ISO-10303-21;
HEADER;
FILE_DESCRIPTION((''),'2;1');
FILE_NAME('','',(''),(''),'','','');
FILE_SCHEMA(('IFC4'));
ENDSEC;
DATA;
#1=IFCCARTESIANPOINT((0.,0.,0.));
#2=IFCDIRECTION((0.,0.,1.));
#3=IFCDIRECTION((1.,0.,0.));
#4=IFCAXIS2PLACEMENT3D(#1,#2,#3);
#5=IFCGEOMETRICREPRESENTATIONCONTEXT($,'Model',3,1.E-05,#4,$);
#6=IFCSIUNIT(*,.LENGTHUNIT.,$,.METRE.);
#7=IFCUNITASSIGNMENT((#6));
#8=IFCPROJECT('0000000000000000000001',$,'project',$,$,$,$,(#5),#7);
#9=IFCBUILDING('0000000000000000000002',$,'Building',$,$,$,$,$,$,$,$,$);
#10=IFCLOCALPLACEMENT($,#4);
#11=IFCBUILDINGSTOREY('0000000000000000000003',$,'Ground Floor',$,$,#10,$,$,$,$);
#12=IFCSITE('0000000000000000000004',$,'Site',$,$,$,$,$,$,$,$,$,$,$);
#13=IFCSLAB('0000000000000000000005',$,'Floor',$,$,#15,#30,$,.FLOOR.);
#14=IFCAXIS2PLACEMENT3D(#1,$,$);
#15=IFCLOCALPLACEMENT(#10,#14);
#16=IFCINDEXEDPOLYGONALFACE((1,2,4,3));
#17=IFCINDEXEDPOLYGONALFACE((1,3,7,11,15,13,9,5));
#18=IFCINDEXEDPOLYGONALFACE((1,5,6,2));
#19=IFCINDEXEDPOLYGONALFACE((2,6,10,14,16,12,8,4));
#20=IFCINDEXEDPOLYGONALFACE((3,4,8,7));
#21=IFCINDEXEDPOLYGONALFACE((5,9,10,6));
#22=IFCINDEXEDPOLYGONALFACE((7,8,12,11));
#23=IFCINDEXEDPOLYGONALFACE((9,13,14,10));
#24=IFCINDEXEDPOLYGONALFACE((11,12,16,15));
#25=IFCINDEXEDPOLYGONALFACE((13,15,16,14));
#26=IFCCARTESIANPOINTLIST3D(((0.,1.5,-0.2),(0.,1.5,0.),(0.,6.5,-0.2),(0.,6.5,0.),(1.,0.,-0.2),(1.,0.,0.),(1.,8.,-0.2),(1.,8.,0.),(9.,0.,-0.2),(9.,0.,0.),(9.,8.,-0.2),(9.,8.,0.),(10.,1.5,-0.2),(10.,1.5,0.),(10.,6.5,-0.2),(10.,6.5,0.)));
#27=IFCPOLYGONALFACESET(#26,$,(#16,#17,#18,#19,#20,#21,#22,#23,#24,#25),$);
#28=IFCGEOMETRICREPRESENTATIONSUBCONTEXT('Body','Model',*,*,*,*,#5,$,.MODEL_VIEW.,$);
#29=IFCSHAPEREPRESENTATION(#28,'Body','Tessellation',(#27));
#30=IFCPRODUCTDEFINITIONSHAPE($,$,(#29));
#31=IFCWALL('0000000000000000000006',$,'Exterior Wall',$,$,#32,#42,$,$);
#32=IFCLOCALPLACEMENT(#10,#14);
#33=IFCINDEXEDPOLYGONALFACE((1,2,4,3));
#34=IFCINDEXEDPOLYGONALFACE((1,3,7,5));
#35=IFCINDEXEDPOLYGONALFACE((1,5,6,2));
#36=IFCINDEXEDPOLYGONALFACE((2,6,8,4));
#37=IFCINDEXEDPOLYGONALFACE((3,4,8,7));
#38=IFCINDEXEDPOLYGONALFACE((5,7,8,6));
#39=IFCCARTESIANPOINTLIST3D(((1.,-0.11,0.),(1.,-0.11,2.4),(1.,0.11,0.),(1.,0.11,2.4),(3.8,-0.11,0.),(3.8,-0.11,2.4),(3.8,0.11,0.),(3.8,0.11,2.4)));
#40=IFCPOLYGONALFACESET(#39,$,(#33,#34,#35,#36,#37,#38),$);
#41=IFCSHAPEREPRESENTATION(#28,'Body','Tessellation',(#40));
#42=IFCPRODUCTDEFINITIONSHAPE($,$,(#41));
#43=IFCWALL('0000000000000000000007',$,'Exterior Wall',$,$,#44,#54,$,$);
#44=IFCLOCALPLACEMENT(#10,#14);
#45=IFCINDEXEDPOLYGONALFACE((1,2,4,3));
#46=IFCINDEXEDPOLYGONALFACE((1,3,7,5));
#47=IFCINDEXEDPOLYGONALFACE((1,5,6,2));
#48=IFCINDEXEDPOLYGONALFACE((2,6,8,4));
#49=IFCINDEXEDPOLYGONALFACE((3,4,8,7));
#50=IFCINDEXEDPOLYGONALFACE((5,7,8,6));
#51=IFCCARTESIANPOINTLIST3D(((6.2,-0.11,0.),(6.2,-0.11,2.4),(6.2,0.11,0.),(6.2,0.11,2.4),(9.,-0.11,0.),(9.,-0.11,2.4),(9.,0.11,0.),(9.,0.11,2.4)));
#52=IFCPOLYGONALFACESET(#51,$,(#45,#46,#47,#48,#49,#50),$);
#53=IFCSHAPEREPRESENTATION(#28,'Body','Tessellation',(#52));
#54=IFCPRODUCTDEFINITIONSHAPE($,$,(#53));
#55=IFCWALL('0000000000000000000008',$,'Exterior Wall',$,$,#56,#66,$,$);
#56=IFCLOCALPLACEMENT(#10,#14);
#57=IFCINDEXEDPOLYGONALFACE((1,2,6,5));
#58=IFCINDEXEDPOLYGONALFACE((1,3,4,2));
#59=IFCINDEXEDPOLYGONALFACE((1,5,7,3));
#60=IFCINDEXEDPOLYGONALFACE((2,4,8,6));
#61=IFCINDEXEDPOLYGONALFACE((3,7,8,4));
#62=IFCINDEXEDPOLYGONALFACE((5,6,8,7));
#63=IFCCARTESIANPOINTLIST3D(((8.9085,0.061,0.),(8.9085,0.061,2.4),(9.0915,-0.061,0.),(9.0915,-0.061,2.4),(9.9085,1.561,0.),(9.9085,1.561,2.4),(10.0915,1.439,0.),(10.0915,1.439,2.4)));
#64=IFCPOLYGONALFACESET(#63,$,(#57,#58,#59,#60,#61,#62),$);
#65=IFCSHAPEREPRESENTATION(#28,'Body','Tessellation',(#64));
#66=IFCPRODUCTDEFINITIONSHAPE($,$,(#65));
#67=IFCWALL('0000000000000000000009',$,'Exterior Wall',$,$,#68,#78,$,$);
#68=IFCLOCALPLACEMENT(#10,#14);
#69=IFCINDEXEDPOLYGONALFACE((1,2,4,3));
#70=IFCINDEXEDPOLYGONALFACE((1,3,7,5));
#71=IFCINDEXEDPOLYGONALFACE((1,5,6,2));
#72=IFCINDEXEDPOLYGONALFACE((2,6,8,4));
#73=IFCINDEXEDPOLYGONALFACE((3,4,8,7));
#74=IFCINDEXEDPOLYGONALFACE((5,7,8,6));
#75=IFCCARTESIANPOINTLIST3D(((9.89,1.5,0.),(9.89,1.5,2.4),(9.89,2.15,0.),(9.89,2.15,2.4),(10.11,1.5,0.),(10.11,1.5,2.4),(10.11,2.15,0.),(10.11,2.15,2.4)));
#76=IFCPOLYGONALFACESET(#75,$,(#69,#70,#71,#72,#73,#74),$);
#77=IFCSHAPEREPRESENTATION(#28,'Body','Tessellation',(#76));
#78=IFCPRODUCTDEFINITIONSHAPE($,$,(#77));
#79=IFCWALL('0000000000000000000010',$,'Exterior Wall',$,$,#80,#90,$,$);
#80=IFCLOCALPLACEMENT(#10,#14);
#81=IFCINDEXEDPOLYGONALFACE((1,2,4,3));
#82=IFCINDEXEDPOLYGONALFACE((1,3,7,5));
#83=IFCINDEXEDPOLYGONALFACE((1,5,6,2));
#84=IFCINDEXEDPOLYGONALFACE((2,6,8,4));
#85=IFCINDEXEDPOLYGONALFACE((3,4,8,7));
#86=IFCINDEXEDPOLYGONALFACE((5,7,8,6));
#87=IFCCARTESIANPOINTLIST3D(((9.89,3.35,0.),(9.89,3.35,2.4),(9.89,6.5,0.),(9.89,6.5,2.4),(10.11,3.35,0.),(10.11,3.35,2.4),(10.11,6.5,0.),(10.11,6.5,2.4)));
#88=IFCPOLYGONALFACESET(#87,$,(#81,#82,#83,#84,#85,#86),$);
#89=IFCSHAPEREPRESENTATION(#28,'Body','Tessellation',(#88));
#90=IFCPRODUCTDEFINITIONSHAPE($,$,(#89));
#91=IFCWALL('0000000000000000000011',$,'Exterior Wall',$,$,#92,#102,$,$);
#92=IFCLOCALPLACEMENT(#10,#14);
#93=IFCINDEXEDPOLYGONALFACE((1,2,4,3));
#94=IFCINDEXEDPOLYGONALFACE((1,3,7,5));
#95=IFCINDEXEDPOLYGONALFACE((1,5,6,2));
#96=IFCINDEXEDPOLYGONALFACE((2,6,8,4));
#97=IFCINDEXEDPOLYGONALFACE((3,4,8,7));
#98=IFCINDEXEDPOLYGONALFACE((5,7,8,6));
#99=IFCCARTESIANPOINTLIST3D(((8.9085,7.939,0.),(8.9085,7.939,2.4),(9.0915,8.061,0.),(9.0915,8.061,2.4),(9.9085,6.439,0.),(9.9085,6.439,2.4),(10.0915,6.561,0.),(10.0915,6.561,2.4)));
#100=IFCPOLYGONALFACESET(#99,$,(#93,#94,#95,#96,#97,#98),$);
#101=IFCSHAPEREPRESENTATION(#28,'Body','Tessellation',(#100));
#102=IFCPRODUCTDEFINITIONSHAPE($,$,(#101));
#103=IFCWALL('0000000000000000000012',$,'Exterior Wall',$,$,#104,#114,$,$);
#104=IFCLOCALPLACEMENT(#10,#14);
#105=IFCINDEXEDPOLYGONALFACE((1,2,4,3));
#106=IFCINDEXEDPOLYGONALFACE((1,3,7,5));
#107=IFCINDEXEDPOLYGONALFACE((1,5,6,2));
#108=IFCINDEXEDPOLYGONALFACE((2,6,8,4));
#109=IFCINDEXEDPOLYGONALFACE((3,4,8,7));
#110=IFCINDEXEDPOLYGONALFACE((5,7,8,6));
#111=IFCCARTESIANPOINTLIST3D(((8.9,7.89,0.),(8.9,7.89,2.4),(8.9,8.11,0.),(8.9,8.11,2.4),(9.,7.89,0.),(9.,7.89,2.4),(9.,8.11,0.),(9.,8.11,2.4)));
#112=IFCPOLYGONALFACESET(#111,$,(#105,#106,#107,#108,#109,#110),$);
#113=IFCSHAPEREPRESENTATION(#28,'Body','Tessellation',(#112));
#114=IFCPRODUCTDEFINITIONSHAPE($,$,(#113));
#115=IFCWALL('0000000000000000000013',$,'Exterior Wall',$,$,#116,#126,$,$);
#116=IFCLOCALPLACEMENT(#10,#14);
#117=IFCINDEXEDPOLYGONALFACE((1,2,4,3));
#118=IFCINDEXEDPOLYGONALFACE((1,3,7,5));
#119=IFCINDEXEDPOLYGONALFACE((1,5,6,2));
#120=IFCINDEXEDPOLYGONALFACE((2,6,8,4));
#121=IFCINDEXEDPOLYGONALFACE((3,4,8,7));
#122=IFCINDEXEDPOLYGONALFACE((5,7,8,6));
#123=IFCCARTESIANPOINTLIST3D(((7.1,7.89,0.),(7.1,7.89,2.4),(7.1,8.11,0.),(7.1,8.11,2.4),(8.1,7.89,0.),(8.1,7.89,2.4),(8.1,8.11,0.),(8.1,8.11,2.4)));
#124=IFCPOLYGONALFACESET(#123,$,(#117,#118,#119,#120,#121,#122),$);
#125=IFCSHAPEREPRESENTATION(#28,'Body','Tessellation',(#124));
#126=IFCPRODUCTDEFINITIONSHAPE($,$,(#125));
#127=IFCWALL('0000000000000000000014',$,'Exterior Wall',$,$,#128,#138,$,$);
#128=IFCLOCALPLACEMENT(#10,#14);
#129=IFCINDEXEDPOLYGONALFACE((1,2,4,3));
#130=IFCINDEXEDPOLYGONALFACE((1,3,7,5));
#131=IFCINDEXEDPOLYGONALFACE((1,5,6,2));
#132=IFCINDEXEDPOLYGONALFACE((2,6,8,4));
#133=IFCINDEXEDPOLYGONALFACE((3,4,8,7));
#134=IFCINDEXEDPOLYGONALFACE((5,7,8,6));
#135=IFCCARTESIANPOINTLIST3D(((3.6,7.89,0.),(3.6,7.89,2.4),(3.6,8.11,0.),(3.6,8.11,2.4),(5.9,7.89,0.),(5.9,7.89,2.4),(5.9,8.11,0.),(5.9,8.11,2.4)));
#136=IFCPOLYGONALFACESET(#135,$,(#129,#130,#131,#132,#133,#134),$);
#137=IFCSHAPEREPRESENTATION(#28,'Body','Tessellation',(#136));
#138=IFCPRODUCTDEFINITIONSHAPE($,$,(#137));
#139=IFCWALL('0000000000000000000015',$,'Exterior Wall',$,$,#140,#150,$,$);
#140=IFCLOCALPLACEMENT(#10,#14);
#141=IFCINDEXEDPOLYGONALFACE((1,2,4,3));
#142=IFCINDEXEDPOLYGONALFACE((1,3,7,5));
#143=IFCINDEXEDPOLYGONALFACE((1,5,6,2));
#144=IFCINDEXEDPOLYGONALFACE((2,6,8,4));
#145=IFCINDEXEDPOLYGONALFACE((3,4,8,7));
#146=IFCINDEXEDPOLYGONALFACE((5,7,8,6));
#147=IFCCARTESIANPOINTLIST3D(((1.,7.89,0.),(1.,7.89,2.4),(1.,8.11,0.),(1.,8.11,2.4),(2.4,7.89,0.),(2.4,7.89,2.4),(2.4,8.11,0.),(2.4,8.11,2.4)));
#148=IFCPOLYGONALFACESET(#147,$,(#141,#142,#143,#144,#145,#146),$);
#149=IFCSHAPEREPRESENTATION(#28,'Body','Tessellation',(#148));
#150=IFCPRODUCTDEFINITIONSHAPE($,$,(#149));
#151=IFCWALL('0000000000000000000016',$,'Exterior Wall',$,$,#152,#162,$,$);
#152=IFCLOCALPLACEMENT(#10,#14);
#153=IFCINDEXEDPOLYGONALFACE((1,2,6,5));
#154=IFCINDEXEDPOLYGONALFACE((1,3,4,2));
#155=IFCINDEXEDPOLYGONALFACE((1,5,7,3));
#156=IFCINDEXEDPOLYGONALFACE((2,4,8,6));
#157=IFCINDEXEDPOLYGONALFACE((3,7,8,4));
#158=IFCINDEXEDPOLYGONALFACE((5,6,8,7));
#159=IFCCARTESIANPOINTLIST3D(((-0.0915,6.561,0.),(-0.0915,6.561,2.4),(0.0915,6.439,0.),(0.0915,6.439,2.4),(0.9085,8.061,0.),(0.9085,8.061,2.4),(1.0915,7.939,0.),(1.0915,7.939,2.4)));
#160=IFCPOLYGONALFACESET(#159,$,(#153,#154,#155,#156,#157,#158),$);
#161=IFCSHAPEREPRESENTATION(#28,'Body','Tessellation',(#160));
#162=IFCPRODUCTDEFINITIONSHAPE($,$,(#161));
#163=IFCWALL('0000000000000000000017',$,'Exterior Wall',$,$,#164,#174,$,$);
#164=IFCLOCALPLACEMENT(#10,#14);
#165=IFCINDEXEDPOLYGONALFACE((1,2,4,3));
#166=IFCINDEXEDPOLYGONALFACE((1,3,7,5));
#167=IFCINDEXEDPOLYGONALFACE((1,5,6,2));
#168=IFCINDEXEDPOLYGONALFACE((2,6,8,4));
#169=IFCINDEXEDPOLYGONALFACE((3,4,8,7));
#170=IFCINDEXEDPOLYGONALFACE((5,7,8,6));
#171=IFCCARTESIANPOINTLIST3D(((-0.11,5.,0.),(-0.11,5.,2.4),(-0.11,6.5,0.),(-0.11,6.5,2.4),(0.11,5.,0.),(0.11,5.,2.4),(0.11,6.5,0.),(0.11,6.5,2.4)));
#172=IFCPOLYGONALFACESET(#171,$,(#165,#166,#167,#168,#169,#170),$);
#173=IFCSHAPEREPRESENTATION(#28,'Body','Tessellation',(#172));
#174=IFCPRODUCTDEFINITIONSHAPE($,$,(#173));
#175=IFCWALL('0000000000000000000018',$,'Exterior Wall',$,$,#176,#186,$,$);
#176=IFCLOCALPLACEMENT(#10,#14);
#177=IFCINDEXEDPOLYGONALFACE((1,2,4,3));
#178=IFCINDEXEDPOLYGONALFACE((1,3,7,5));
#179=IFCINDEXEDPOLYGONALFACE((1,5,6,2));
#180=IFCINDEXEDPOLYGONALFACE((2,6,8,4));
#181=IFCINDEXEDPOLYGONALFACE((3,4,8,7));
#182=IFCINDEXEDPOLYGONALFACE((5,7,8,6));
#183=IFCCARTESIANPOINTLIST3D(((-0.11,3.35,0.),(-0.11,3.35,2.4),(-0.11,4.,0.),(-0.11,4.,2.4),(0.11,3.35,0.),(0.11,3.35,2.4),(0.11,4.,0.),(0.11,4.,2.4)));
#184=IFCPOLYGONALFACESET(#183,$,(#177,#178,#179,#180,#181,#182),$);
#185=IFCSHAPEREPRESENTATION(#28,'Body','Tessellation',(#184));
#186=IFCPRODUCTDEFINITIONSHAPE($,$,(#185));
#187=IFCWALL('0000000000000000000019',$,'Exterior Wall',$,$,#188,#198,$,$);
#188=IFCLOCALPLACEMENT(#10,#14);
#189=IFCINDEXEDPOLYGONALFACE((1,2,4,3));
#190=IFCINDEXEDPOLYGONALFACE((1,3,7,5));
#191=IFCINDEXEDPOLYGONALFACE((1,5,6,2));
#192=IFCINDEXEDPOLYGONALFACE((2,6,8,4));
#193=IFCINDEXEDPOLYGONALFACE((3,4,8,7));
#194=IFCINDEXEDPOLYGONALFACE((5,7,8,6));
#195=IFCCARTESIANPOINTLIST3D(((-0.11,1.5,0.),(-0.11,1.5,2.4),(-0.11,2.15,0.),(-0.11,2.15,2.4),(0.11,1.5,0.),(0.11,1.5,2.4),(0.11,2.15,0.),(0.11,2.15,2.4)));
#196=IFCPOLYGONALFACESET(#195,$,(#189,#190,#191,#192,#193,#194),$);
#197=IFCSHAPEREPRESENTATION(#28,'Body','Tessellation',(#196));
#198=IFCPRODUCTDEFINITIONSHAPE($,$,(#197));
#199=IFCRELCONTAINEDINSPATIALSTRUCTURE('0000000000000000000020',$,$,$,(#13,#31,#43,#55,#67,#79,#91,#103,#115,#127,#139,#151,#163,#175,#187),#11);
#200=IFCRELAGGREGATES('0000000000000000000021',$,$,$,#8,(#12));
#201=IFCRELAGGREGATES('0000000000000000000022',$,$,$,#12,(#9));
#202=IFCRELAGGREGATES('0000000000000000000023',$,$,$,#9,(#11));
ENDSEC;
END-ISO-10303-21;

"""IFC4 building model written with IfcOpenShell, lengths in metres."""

from ifc_helpers import new_model, si_unit, frame, origin_with_axes, place, context, subcontext, project, spatial, indexed_curve, outline, extrude, element, save


model = new_model("IFC4")

# Units and contexts
model_context = context("Model", 3, precision=1e-05, world=origin_with_axes())
body_context = subcontext(model_context, "Body", "Model", "MODEL_VIEW")
ifc_project = project(units=[si_unit("LENGTHUNIT", "METRE")], contexts=[model_context])

# Site, building, storey
site = spatial("IfcSite", under=ifc_project, Name="Site")
building = spatial("IfcBuilding", under=site, Name="Building")
storey_placement = place(None, origin_with_axes())
storey = spatial("IfcBuildingStorey", under=building, at=storey_placement, Name="Ground Floor")

# Slab
slab_placement = place(storey_placement, frame((0.0, 0.0, -0.2), z_axis=(0.0, 0.0, 1.0), x_axis=(1.0, 0.0, 0.0)))
element("IfcSlab", 1, at=slab_placement, inside=storey, Name="Floor", PredefinedType="FLOOR", context=body_context, shape_type="SweptSolid", body=[
    extrude(outline(indexed_curve([(1.0, 0.0), (9.0, 0.0), (10.0, 1.5), (10.0, 6.5), (9.0, 8.0), (1.0, 8.0), (0.0, 6.5), (0.0, 1.5)])), None, (0.0, 0.0, 1.0), 0.2),
])

# Walls
for number, where, z_axis, x_axis, name in (
    (2, (1.0, 0.0, 0.0), (0.0, 0.0, 1.0), (1.0, 0.0, 0.0), "Exterior Wall"),
    (3, (6.2, 0.0, 0.0), (0.0, 0.0, 1.0), (1.0, 0.0, 0.0), "Exterior Wall"),
):
    element("IfcWall", number, at=place(storey_placement, frame(where, z_axis=z_axis, x_axis=x_axis)), inside=storey, Name=name, context=body_context, shape_type="SweptSolid", body=[
        extrude(outline(indexed_curve([(0.0, 0.0), (0.0, 0.22), (2.8, 0.22), (2.8, 0.0), (0.0, 0.0)], self_intersect=False)), frame((0.0, -0.11, 0.0), z_axis=(0.0, 0.0, 1.0), x_axis=(1.0, 0.0, 0.0)), (0.0, 0.0, 1.0), 2.4),
    ])
wall_1_placement = place(storey_placement, frame((9.0, 0.0, 0.0), z_axis=(0.0, 0.0, 1.0), x_axis=(0.5547, 0.83205, 0.0)))
element("IfcWall", 4, at=wall_1_placement, inside=storey, Name="Exterior Wall", context=body_context, shape_type="SweptSolid", body=[
    extrude(outline(indexed_curve([(0.0, 0.0), (0.0, 0.22), (1.8028, 0.22), (1.8028, 0.0), (0.0, 0.0)], self_intersect=False)), frame((0.0, -0.11, 0.0), z_axis=(0.0, 0.0, 1.0), x_axis=(1.0, 0.0, 0.0)), (0.0, 0.0, 1.0), 2.4),
])
wall_2_placement = place(storey_placement, frame((10.0, 1.5, 0.0), z_axis=(0.0, 0.0, 1.0), x_axis=(0.0, 1.0, 0.0)))
element("IfcWall", 5, at=wall_2_placement, inside=storey, Name="Exterior Wall", context=body_context, shape_type="SweptSolid", body=[
    extrude(outline(indexed_curve([(0.0, 0.0), (0.0, 0.22), (0.65, 0.22), (0.65, 0.0), (0.0, 0.0)], self_intersect=False)), frame((0.0, -0.11, 0.0), z_axis=(0.0, 0.0, 1.0), x_axis=(1.0, 0.0, 0.0)), (0.0, 0.0, 1.0), 2.4),
])
wall_3_placement = place(storey_placement, frame((10.0, 3.35, 0.0), z_axis=(0.0, 0.0, 1.0), x_axis=(0.0, 1.0, 0.0)))
element("IfcWall", 6, at=wall_3_placement, inside=storey, Name="Exterior Wall", context=body_context, shape_type="SweptSolid", body=[
    extrude(outline(indexed_curve([(0.0, 0.0), (0.0, 0.22), (3.15, 0.22), (3.15, 0.0), (0.0, 0.0)], self_intersect=False)), frame((0.0, -0.11, 0.0), z_axis=(0.0, 0.0, 1.0), x_axis=(1.0, 0.0, 0.0)), (0.0, 0.0, 1.0), 2.4),
])
wall_4_placement = place(storey_placement, frame((10.0, 6.5, 0.0), z_axis=(0.0, 0.0, 1.0), x_axis=(-0.5547, 0.83205, 0.0)))
element("IfcWall", 7, at=wall_4_placement, inside=storey, Name="Exterior Wall", context=body_context, shape_type="SweptSolid", body=[
    extrude(outline(indexed_curve([(0.0, 0.0), (0.0, 0.22), (1.8028, 0.22), (1.8028, 0.0), (0.0, 0.0)], self_intersect=False)), frame((0.0, -0.11, 0.0), z_axis=(0.0, 0.0, 1.0), x_axis=(1.0, 0.0, 0.0)), (0.0, 0.0, 1.0), 2.4),
])
wall_5_placement = place(storey_placement, frame((9.0, 8.0, 0.0), z_axis=(0.0, 0.0, 1.0), x_axis=(-1.0, 0.0, 0.0)))
element("IfcWall", 8, at=wall_5_placement, inside=storey, Name="Exterior Wall", context=body_context, shape_type="SweptSolid", body=[
    extrude(outline(indexed_curve([(0.0, 0.0), (0.0, 0.22), (0.1, 0.22), (0.1, 0.0), (0.0, 0.0)], self_intersect=False)), frame((0.0, -0.11, 0.0), z_axis=(0.0, 0.0, 1.0), x_axis=(1.0, 0.0, 0.0)), (0.0, 0.0, 1.0), 2.4),
])
wall_6_placement = place(storey_placement, frame((8.1, 8.0, 0.0), z_axis=(0.0, 0.0, 1.0), x_axis=(-1.0, 0.0, 0.0)))
element("IfcWall", 9, at=wall_6_placement, inside=storey, Name="Exterior Wall", context=body_context, shape_type="SweptSolid", body=[
    extrude(outline(indexed_curve([(0.0, 0.0), (0.0, 0.22), (1.0, 0.22), (1.0, 0.0), (0.0, 0.0)], self_intersect=False)), frame((0.0, -0.11, 0.0), z_axis=(0.0, 0.0, 1.0), x_axis=(1.0, 0.0, 0.0)), (0.0, 0.0, 1.0), 2.4),
])
wall_7_placement = place(storey_placement, frame((5.9, 8.0, 0.0), z_axis=(0.0, 0.0, 1.0), x_axis=(-1.0, 0.0, 0.0)))
element("IfcWall", 10, at=wall_7_placement, inside=storey, Name="Exterior Wall", context=body_context, shape_type="SweptSolid", body=[
    extrude(outline(indexed_curve([(0.0, 0.0), (0.0, 0.22), (2.3, 0.22), (2.3, 0.0), (0.0, 0.0)], self_intersect=False)), frame((0.0, -0.11, 0.0), z_axis=(0.0, 0.0, 1.0), x_axis=(1.0, 0.0, 0.0)), (0.0, 0.0, 1.0), 2.4),
])
wall_8_placement = place(storey_placement, frame((2.4, 8.0, 0.0), z_axis=(0.0, 0.0, 1.0), x_axis=(-1.0, 0.0, 0.0)))
element("IfcWall", 11, at=wall_8_placement, inside=storey, Name="Exterior Wall", context=body_context, shape_type="SweptSolid", body=[
    extrude(outline(indexed_curve([(0.0, 0.0), (0.0, 0.22), (1.4, 0.22), (1.4, 0.0), (0.0, 0.0)], self_intersect=False)), frame((0.0, -0.11, 0.0), z_axis=(0.0, 0.0, 1.0), x_axis=(1.0, 0.0, 0.0)), (0.0, 0.0, 1.0), 2.4),
])
wall_9_placement = place(storey_placement, frame((1.0, 8.0, 0.0), z_axis=(0.0, 0.0, 1.0), x_axis=(-0.5547, -0.83205, 0.0)))
element("IfcWall", 12, at=wall_9_placement, inside=storey, Name="Exterior Wall", context=body_context, shape_type="SweptSolid", body=[
    extrude(outline(indexed_curve([(0.0, 0.0), (0.0, 0.22), (1.8028, 0.22), (1.8028, 0.0), (0.0, 0.0)], self_intersect=False)), frame((0.0, -0.11, 0.0), z_axis=(0.0, 0.0, 1.0), x_axis=(1.0, 0.0, 0.0)), (0.0, 0.0, 1.0), 2.4),
])
wall_10_placement = place(storey_placement, frame((0.0, 6.5, 0.0), z_axis=(0.0, 0.0, 1.0), x_axis=(0.0, -1.0, 0.0)))
element("IfcWall", 13, at=wall_10_placement, inside=storey, Name="Exterior Wall", context=body_context, shape_type="SweptSolid", body=[
    extrude(outline(indexed_curve([(0.0, 0.0), (0.0, 0.22), (1.5, 0.22), (1.5, 0.0), (0.0, 0.0)], self_intersect=False)), frame((0.0, -0.11, 0.0), z_axis=(0.0, 0.0, 1.0), x_axis=(1.0, 0.0, 0.0)), (0.0, 0.0, 1.0), 2.4),
])
wall_11_placement = place(storey_placement, frame((0.0, 4.0, 0.0), z_axis=(0.0, 0.0, 1.0), x_axis=(0.0, -1.0, 0.0)))
element("IfcWall", 14, at=wall_11_placement, inside=storey, Name="Exterior Wall", context=body_context, shape_type="SweptSolid", body=[
    extrude(outline(indexed_curve([(0.0, 0.0), (0.0, 0.22), (0.65, 0.22), (0.65, 0.0), (0.0, 0.0)], self_intersect=False)), frame((0.0, -0.11, 0.0), z_axis=(0.0, 0.0, 1.0), x_axis=(1.0, 0.0, 0.0)), (0.0, 0.0, 1.0), 2.4),
])
wall_12_placement = place(storey_placement, frame((0.0, 2.15, 0.0), z_axis=(0.0, 0.0, 1.0), x_axis=(0.0, -1.0, 0.0)))
element("IfcWall", 15, at=wall_12_placement, inside=storey, Name="Exterior Wall", context=body_context, shape_type="SweptSolid", body=[
    extrude(outline(indexed_curve([(0.0, 0.0), (0.0, 0.22), (0.65, 0.22), (0.65, 0.0), (0.0, 0.0)], self_intersect=False)), frame((0.0, -0.11, 0.0), z_axis=(0.0, 0.0, 1.0), x_axis=(1.0, 0.0, 0.0)), (0.0, 0.0, 1.0), 2.4),
])

save(model, "model.ifc")
